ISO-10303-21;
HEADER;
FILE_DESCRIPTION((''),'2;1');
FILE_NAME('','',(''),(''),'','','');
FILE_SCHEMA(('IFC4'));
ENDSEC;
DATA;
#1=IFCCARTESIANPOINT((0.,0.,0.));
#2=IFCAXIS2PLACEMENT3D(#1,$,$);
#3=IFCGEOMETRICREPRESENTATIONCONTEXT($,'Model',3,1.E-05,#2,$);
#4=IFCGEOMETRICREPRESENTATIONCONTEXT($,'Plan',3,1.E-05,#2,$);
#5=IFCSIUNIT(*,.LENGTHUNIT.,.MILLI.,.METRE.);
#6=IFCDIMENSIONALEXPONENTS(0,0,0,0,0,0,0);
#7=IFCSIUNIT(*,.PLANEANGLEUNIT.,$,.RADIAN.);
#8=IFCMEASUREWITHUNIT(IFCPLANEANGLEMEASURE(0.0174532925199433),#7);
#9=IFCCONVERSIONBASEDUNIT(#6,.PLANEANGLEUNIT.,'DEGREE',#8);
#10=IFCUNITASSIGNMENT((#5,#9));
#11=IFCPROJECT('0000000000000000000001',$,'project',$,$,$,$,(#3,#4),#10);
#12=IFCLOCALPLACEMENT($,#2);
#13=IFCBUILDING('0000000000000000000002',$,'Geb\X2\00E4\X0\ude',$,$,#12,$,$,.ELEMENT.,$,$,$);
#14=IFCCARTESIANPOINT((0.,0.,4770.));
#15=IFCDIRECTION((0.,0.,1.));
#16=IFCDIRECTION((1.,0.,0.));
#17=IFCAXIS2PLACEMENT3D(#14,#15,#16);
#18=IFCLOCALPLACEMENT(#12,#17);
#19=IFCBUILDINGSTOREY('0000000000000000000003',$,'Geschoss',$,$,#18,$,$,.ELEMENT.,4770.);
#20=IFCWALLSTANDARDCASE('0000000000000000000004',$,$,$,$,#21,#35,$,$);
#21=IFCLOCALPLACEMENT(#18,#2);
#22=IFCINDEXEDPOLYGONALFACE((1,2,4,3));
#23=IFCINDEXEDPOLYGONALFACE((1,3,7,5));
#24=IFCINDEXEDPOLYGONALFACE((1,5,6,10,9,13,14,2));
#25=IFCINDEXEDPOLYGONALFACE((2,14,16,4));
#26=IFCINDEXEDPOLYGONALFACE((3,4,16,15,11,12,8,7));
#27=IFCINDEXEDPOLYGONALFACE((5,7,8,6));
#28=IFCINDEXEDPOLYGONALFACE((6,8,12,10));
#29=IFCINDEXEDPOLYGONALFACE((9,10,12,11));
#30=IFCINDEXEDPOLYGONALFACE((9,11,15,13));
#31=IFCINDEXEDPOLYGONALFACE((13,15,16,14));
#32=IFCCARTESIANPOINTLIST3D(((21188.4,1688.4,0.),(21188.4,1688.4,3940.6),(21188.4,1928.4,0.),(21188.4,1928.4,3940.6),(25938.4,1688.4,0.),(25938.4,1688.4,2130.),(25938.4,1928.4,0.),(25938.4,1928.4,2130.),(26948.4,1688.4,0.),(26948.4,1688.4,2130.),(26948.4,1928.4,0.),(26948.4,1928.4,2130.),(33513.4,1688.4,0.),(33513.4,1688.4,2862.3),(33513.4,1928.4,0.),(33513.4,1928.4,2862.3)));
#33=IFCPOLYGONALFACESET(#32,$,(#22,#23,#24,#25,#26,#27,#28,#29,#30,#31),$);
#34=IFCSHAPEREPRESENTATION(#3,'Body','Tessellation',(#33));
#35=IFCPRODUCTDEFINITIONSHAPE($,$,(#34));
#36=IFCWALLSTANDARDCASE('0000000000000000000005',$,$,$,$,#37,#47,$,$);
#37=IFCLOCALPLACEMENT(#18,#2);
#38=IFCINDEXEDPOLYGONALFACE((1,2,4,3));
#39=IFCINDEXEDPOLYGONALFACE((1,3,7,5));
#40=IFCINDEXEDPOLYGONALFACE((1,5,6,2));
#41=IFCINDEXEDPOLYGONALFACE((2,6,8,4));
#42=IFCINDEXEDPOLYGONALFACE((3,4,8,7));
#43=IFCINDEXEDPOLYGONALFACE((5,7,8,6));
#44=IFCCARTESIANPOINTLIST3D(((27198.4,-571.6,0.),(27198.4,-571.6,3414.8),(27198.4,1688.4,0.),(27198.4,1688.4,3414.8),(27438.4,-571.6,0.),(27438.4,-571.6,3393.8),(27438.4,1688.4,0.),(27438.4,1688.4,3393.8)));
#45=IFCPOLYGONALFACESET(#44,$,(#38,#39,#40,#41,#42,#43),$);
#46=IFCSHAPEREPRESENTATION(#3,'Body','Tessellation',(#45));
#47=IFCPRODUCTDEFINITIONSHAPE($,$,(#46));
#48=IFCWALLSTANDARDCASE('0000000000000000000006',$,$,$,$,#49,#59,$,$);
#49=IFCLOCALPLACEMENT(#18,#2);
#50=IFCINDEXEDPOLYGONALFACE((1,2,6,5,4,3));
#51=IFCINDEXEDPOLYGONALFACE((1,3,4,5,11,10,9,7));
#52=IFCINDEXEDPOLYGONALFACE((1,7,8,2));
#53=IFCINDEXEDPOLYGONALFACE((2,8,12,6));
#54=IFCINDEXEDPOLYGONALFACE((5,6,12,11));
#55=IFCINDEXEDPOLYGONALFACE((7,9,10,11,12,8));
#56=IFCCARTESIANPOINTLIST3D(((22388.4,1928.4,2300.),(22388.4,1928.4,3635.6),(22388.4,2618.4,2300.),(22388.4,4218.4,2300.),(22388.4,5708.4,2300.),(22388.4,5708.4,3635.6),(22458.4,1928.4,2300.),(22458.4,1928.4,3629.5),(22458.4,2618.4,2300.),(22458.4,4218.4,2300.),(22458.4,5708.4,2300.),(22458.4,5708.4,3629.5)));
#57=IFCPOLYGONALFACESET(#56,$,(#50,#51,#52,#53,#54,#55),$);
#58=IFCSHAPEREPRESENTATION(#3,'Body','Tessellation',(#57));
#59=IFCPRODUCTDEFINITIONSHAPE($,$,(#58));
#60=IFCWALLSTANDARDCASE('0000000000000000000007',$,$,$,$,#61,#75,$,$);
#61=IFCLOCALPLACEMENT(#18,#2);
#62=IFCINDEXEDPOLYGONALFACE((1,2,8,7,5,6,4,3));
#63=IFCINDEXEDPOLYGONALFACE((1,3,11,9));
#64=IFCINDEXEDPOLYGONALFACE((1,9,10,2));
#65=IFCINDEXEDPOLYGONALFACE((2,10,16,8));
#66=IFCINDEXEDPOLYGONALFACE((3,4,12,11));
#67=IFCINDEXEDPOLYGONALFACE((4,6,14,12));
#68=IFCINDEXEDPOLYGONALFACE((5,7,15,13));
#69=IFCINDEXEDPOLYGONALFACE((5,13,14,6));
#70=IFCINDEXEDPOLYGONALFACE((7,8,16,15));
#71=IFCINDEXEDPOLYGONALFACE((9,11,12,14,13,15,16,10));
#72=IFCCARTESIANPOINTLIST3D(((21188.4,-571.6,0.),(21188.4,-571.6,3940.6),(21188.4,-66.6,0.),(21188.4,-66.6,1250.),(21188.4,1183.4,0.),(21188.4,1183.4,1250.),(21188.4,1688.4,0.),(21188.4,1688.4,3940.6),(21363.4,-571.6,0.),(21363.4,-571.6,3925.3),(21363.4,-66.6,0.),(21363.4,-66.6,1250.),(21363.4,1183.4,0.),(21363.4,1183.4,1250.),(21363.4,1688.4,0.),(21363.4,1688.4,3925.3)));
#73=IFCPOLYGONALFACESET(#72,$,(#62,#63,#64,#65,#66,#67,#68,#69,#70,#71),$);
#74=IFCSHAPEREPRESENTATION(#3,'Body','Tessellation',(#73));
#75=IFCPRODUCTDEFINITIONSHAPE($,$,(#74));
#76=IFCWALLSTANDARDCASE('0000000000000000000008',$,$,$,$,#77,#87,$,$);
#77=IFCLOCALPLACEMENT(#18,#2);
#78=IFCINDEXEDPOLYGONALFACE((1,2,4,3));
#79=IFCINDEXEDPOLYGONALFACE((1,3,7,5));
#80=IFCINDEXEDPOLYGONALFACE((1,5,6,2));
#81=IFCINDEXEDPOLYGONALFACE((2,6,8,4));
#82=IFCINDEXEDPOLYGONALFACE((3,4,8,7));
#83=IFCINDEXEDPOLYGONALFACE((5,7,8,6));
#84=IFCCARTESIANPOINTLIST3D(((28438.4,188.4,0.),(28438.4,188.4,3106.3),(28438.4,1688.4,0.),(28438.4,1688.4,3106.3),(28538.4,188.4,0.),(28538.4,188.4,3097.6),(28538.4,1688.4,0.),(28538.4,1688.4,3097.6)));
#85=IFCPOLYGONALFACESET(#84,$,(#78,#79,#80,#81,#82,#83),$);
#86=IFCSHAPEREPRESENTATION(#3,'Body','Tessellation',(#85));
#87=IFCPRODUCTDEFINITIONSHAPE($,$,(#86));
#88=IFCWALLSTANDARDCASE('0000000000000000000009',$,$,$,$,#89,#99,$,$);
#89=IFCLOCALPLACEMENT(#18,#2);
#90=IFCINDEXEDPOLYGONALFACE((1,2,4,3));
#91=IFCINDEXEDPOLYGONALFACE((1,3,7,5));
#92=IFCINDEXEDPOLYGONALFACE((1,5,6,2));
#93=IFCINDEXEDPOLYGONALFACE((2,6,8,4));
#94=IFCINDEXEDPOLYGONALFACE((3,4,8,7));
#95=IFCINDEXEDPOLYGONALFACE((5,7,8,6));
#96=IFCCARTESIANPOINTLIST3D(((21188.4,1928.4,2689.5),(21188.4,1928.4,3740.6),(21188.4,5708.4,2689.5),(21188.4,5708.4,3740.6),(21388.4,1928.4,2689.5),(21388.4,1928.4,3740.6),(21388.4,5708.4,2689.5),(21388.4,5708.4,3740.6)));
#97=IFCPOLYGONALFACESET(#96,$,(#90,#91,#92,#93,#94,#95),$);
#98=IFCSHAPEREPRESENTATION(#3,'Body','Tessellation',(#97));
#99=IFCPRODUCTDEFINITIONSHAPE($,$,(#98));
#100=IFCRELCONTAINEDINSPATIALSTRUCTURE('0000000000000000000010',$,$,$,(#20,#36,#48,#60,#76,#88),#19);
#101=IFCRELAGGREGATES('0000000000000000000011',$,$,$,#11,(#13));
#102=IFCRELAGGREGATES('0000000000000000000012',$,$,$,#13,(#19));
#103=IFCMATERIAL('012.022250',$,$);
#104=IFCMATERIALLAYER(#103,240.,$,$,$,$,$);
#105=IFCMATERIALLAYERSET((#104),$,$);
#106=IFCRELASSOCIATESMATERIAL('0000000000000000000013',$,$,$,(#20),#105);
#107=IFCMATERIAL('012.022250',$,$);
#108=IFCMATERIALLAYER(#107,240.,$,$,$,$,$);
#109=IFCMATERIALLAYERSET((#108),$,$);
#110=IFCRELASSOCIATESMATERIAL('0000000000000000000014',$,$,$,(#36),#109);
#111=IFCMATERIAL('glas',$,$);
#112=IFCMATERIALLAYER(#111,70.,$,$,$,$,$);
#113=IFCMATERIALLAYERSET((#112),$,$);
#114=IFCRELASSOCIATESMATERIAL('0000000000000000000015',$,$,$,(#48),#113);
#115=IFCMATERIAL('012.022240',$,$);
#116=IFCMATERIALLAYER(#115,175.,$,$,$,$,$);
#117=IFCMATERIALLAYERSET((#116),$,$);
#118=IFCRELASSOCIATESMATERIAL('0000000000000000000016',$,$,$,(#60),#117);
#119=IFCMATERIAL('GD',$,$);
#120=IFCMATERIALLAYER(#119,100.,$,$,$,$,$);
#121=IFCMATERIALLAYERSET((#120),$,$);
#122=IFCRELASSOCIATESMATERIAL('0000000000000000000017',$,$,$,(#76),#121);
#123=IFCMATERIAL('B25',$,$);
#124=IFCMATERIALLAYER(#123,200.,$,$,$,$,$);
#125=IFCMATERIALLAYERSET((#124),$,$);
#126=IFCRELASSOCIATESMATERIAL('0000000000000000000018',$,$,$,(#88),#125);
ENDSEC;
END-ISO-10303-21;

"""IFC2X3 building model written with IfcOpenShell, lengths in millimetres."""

from ifc_helpers import new_model, entity, si_unit, converted_unit, frame, frame_2d, origin, origin_with_axes, place, context, project, spatial, rectangle, extrude, clip, halfspace, material, layer, layer_set, layer_usage, element, save


model = new_model("IFC2X3")

# Units and contexts
model_context = context("Model", 3, precision=1e-05, world=origin())
plan_context = context("Plan", 3, precision=1e-05, world=origin())
ifc_project = project(units=[si_unit("LENGTHUNIT", "METRE", prefix="MILLI"), converted_unit("PLANEANGLEUNIT", "DEGREE", entity("IfcPlaneAngleMeasure", 0.0174532925199433), si_unit("PLANEANGLEUNIT", "RADIAN"), dimensions=[0, 0, 0, 0, 0, 0, 0])], contexts=[model_context, plan_context])

# Building, storey
building_placement = place(None, origin())
building = spatial("IfcBuilding", under=ifc_project, at=building_placement, Name="Gebäude", CompositionType="ELEMENT")
storey_placement = place(building_placement, frame((0.0, 0.0, 4770.0), z_axis=(0.0, 0.0, 1.0), x_axis=(1.0, 0.0, 0.0)))
storey = spatial("IfcBuildingStorey", under=building, at=storey_placement, Name="Geschoss", CompositionType="ELEMENT", Elevation=4770.0)

# Wall, opening
ifc_material_1 = material(Name="012.022250")
ifc_layer_1 = layer(ifc_material_1, 240.0)
ifc_layer_set_1 = layer_set([ifc_layer_1])
ifc_layer_usage_1 = layer_usage(ifc_layer_set_1, "AXIS2", "POSITIVE", 0.0)
wall_1_placement = place(storey_placement, frame((33513.4, 1928.4, 0.0), z_axis=(0.0, 0.0, 1.0), x_axis=(-1.0, 0.0, 0.0)))
wall_1 = element("IfcWallStandardCase", 1, at=wall_1_placement, inside=storey, material=ifc_layer_usage_1, context=model_context, shape_type="Clipping", body=[
    clip(extrude(rectangle(XDim=12325.0, YDim=240.0, at=frame_2d((6162.5, 120.0), x_axis=(1.0, 0.0))), origin_with_axes(), (0.0, 0.0, 1.0), 3940.6), halfspace(frame((0.0, 0.0, 2862.3), z_axis=(0.087156, 0.0, -0.996195), x_axis=(1.0, 0.0, 0.0)), True)),
])
opening_1_placement = place(wall_1_placement, frame((6565.0, 0.0, 0.0), z_axis=(0.0, 1.0, 0.0), x_axis=(0.0, 0.0, 1.0)))
element("IfcOpeningElement", 2, at=opening_1_placement, cuts=wall_1, ObjectType="Opening", context=model_context, shape_type="SweptSolid", body=[
    extrude(rectangle(XDim=2130.0, YDim=1010.0, at=frame_2d((1065.0, 505.0), x_axis=(1.0, 0.0))), origin_with_axes(), (0.0, 0.0, 1.0), 240.0),
])

# Wall
ifc_material_2 = material(Name="012.022250")
ifc_layer_2 = layer(ifc_material_2, 240.0)
ifc_layer_set_2 = layer_set([ifc_layer_2])
ifc_layer_usage_2 = layer_usage(ifc_layer_set_2, "AXIS2", "POSITIVE", 0.0)
wall_2_placement = place(storey_placement, frame((27198.4, 1688.4, 0.0), z_axis=(0.0, 0.0, 1.0), x_axis=(0.0, -1.0, 0.0)))
element("IfcWallStandardCase", 3, at=wall_2_placement, inside=storey, material=ifc_layer_usage_2, context=model_context, shape_type="Clipping", body=[
    clip(extrude(rectangle(XDim=2260.0, YDim=240.0, at=frame_2d((1130.0, 120.0), x_axis=(1.0, 0.0))), origin_with_axes(), (0.0, 0.0, 1.0), 3414.8), halfspace(frame((0.0, 0.0, 3414.8), z_axis=(0.0, -0.087156, -0.996195), x_axis=(1.0, 0.0, 0.0)), True)),
])

# Wall, openings
ifc_material_3 = material(Name="glas")
ifc_layer_3 = layer(ifc_material_3, 70.0)
ifc_layer_set_3 = layer_set([ifc_layer_3])
ifc_layer_usage_3 = layer_usage(ifc_layer_set_3, "AXIS2", "POSITIVE", 0.0)
wall_3_placement = place(storey_placement, frame((22458.4, 1928.4, 0.0), z_axis=(0.0, 0.0, 1.0), x_axis=(0.0, 1.0, 0.0)))
wall_3 = element("IfcWallStandardCase", 4, at=wall_3_placement, inside=storey, material=ifc_layer_usage_3, context=model_context, shape_type="Clipping", body=[
    clip(extrude(rectangle(XDim=3780.0, YDim=70.0, at=frame_2d((1890.0, 35.0), x_axis=(1.0, 0.0))), origin_with_axes(), (0.0, 0.0, 1.0), 3635.6), halfspace(frame((0.0, 0.0, 3629.5), z_axis=(0.0, 0.087156, -0.996195), x_axis=(1.0, 0.0, 0.0)), True)),
])
opening_2_placement = place(wall_3_placement, frame((0.0, 0.0, 0.0), z_axis=(0.0, 1.0, 0.0), x_axis=(0.0, 0.0, 1.0)))
element("IfcOpeningElement", 5, at=opening_2_placement, cuts=wall_3, ObjectType="Opening", context=model_context, shape_type="SweptSolid", body=[
    extrude(rectangle(XDim=2300.0, YDim=690.0, at=frame_2d((1150.0, 345.0), x_axis=(1.0, 0.0))), origin_with_axes(), (0.0, 0.0, 1.0), 70.0),
])
opening_3_placement = place(wall_3_placement, frame((2290.0, 0.0, 0.0), z_axis=(0.0, 1.0, 0.0), x_axis=(0.0, 0.0, 1.0)))
element("IfcOpeningElement", 6, at=opening_3_placement, cuts=wall_3, ObjectType="Opening", context=model_context, shape_type="SweptSolid", body=[
    extrude(rectangle(XDim=2300.0, YDim=1490.0, at=frame_2d((1150.0, 745.0), x_axis=(1.0, 0.0))), origin_with_axes(), (0.0, 0.0, 1.0), 70.0),
])
opening_4_placement = place(wall_3_placement, frame((690.0, 0.0, 0.0), z_axis=(0.0, 1.0, 0.0), x_axis=(0.0, 0.0, 1.0)))
element("IfcOpeningElement", 7, at=opening_4_placement, cuts=wall_3, ObjectType="Opening", context=model_context, shape_type="SweptSolid", body=[
    extrude(rectangle(XDim=2300.0, YDim=1600.0, at=frame_2d((1150.0, 800.0), x_axis=(1.0, 0.0))), origin_with_axes(), (0.0, 0.0, 1.0), 70.0),
])

# Wall, opening
ifc_material_4 = material(Name="012.022240")
ifc_layer_4 = layer(ifc_material_4, 175.0)
ifc_layer_set_4 = layer_set([ifc_layer_4])
ifc_layer_usage_4 = layer_usage(ifc_layer_set_4, "AXIS2", "POSITIVE", 0.0)
wall_4_placement = place(storey_placement, frame((21188.4, 1688.4, 0.0), z_axis=(0.0, 0.0, 1.0), x_axis=(0.0, -1.0, 0.0)))
wall_4 = element("IfcWallStandardCase", 8, at=wall_4_placement, inside=storey, material=ifc_layer_usage_4, context=model_context, shape_type="Clipping", body=[
    clip(extrude(rectangle(XDim=2260.0, YDim=175.0, at=frame_2d((1130.0, 87.5), x_axis=(1.0, 0.0))), origin_with_axes(), (0.0, 0.0, 1.0), 3940.6), halfspace(frame((0.0, 175.0, 3925.3), z_axis=(0.0, -0.087156, -0.996195), x_axis=(1.0, 0.0, 0.0)), True)),
])
opening_5_placement = place(wall_4_placement, frame((505.0, 0.0, 0.0), z_axis=(0.0, 1.0, 0.0), x_axis=(0.0, 0.0, 1.0)))
element("IfcOpeningElement", 9, at=opening_5_placement, cuts=wall_4, ObjectType="Opening", context=model_context, shape_type="SweptSolid", body=[
    extrude(rectangle(XDim=1250.0, YDim=1250.0, at=frame_2d((625.0, 625.0), x_axis=(1.0, 0.0))), origin_with_axes(), (0.0, 0.0, 1.0), 175.0),
])

# Walls
ifc_material_5 = material(Name="GD")
ifc_layer_5 = layer(ifc_material_5, 100.0)
ifc_layer_set_5 = layer_set([ifc_layer_5])
ifc_layer_usage_5 = layer_usage(ifc_layer_set_5, "AXIS2", "POSITIVE", 0.0)
wall_5_placement = place(storey_placement, frame((28438.4, 1688.4, 0.0), z_axis=(0.0, 0.0, 1.0), x_axis=(0.0, -1.0, 0.0)))
element("IfcWallStandardCase", 10, at=wall_5_placement, inside=storey, material=ifc_layer_usage_5, context=model_context, shape_type="Clipping", body=[
    clip(extrude(rectangle(XDim=1500.0, YDim=100.0, at=frame_2d((750.0, 50.0), x_axis=(1.0, 0.0))), origin_with_axes(), (0.0, 0.0, 1.0), 3106.3), halfspace(frame((0.0, 0.0, 3106.3), z_axis=(0.0, -0.087156, -0.996195), x_axis=(1.0, 0.0, 0.0)), True)),
])
ifc_material_6 = material(Name="B25")
ifc_layer_6 = layer(ifc_material_6, 200.0)
ifc_layer_set_6 = layer_set([ifc_layer_6])
ifc_layer_usage_6 = layer_usage(ifc_layer_set_6, "AXIS2", "POSITIVE", 0.0)
wall_6_placement = place(storey_placement, frame((21188.4, 5708.4, 2689.5), z_axis=(0.0, 0.0, 1.0), x_axis=(0.0, -1.0, 0.0)))
element("IfcWallStandardCase", 11, at=wall_6_placement, inside=storey, material=ifc_layer_usage_6, context=model_context, shape_type="SweptSolid", body=[
    extrude(rectangle(XDim=3780.0, YDim=200.0, at=frame_2d((1890.0, 100.0), x_axis=(1.0, 0.0))), origin_with_axes(), (0.0, 0.0, 1.0), 1051.1),
])

save(model, "model.ifc")
